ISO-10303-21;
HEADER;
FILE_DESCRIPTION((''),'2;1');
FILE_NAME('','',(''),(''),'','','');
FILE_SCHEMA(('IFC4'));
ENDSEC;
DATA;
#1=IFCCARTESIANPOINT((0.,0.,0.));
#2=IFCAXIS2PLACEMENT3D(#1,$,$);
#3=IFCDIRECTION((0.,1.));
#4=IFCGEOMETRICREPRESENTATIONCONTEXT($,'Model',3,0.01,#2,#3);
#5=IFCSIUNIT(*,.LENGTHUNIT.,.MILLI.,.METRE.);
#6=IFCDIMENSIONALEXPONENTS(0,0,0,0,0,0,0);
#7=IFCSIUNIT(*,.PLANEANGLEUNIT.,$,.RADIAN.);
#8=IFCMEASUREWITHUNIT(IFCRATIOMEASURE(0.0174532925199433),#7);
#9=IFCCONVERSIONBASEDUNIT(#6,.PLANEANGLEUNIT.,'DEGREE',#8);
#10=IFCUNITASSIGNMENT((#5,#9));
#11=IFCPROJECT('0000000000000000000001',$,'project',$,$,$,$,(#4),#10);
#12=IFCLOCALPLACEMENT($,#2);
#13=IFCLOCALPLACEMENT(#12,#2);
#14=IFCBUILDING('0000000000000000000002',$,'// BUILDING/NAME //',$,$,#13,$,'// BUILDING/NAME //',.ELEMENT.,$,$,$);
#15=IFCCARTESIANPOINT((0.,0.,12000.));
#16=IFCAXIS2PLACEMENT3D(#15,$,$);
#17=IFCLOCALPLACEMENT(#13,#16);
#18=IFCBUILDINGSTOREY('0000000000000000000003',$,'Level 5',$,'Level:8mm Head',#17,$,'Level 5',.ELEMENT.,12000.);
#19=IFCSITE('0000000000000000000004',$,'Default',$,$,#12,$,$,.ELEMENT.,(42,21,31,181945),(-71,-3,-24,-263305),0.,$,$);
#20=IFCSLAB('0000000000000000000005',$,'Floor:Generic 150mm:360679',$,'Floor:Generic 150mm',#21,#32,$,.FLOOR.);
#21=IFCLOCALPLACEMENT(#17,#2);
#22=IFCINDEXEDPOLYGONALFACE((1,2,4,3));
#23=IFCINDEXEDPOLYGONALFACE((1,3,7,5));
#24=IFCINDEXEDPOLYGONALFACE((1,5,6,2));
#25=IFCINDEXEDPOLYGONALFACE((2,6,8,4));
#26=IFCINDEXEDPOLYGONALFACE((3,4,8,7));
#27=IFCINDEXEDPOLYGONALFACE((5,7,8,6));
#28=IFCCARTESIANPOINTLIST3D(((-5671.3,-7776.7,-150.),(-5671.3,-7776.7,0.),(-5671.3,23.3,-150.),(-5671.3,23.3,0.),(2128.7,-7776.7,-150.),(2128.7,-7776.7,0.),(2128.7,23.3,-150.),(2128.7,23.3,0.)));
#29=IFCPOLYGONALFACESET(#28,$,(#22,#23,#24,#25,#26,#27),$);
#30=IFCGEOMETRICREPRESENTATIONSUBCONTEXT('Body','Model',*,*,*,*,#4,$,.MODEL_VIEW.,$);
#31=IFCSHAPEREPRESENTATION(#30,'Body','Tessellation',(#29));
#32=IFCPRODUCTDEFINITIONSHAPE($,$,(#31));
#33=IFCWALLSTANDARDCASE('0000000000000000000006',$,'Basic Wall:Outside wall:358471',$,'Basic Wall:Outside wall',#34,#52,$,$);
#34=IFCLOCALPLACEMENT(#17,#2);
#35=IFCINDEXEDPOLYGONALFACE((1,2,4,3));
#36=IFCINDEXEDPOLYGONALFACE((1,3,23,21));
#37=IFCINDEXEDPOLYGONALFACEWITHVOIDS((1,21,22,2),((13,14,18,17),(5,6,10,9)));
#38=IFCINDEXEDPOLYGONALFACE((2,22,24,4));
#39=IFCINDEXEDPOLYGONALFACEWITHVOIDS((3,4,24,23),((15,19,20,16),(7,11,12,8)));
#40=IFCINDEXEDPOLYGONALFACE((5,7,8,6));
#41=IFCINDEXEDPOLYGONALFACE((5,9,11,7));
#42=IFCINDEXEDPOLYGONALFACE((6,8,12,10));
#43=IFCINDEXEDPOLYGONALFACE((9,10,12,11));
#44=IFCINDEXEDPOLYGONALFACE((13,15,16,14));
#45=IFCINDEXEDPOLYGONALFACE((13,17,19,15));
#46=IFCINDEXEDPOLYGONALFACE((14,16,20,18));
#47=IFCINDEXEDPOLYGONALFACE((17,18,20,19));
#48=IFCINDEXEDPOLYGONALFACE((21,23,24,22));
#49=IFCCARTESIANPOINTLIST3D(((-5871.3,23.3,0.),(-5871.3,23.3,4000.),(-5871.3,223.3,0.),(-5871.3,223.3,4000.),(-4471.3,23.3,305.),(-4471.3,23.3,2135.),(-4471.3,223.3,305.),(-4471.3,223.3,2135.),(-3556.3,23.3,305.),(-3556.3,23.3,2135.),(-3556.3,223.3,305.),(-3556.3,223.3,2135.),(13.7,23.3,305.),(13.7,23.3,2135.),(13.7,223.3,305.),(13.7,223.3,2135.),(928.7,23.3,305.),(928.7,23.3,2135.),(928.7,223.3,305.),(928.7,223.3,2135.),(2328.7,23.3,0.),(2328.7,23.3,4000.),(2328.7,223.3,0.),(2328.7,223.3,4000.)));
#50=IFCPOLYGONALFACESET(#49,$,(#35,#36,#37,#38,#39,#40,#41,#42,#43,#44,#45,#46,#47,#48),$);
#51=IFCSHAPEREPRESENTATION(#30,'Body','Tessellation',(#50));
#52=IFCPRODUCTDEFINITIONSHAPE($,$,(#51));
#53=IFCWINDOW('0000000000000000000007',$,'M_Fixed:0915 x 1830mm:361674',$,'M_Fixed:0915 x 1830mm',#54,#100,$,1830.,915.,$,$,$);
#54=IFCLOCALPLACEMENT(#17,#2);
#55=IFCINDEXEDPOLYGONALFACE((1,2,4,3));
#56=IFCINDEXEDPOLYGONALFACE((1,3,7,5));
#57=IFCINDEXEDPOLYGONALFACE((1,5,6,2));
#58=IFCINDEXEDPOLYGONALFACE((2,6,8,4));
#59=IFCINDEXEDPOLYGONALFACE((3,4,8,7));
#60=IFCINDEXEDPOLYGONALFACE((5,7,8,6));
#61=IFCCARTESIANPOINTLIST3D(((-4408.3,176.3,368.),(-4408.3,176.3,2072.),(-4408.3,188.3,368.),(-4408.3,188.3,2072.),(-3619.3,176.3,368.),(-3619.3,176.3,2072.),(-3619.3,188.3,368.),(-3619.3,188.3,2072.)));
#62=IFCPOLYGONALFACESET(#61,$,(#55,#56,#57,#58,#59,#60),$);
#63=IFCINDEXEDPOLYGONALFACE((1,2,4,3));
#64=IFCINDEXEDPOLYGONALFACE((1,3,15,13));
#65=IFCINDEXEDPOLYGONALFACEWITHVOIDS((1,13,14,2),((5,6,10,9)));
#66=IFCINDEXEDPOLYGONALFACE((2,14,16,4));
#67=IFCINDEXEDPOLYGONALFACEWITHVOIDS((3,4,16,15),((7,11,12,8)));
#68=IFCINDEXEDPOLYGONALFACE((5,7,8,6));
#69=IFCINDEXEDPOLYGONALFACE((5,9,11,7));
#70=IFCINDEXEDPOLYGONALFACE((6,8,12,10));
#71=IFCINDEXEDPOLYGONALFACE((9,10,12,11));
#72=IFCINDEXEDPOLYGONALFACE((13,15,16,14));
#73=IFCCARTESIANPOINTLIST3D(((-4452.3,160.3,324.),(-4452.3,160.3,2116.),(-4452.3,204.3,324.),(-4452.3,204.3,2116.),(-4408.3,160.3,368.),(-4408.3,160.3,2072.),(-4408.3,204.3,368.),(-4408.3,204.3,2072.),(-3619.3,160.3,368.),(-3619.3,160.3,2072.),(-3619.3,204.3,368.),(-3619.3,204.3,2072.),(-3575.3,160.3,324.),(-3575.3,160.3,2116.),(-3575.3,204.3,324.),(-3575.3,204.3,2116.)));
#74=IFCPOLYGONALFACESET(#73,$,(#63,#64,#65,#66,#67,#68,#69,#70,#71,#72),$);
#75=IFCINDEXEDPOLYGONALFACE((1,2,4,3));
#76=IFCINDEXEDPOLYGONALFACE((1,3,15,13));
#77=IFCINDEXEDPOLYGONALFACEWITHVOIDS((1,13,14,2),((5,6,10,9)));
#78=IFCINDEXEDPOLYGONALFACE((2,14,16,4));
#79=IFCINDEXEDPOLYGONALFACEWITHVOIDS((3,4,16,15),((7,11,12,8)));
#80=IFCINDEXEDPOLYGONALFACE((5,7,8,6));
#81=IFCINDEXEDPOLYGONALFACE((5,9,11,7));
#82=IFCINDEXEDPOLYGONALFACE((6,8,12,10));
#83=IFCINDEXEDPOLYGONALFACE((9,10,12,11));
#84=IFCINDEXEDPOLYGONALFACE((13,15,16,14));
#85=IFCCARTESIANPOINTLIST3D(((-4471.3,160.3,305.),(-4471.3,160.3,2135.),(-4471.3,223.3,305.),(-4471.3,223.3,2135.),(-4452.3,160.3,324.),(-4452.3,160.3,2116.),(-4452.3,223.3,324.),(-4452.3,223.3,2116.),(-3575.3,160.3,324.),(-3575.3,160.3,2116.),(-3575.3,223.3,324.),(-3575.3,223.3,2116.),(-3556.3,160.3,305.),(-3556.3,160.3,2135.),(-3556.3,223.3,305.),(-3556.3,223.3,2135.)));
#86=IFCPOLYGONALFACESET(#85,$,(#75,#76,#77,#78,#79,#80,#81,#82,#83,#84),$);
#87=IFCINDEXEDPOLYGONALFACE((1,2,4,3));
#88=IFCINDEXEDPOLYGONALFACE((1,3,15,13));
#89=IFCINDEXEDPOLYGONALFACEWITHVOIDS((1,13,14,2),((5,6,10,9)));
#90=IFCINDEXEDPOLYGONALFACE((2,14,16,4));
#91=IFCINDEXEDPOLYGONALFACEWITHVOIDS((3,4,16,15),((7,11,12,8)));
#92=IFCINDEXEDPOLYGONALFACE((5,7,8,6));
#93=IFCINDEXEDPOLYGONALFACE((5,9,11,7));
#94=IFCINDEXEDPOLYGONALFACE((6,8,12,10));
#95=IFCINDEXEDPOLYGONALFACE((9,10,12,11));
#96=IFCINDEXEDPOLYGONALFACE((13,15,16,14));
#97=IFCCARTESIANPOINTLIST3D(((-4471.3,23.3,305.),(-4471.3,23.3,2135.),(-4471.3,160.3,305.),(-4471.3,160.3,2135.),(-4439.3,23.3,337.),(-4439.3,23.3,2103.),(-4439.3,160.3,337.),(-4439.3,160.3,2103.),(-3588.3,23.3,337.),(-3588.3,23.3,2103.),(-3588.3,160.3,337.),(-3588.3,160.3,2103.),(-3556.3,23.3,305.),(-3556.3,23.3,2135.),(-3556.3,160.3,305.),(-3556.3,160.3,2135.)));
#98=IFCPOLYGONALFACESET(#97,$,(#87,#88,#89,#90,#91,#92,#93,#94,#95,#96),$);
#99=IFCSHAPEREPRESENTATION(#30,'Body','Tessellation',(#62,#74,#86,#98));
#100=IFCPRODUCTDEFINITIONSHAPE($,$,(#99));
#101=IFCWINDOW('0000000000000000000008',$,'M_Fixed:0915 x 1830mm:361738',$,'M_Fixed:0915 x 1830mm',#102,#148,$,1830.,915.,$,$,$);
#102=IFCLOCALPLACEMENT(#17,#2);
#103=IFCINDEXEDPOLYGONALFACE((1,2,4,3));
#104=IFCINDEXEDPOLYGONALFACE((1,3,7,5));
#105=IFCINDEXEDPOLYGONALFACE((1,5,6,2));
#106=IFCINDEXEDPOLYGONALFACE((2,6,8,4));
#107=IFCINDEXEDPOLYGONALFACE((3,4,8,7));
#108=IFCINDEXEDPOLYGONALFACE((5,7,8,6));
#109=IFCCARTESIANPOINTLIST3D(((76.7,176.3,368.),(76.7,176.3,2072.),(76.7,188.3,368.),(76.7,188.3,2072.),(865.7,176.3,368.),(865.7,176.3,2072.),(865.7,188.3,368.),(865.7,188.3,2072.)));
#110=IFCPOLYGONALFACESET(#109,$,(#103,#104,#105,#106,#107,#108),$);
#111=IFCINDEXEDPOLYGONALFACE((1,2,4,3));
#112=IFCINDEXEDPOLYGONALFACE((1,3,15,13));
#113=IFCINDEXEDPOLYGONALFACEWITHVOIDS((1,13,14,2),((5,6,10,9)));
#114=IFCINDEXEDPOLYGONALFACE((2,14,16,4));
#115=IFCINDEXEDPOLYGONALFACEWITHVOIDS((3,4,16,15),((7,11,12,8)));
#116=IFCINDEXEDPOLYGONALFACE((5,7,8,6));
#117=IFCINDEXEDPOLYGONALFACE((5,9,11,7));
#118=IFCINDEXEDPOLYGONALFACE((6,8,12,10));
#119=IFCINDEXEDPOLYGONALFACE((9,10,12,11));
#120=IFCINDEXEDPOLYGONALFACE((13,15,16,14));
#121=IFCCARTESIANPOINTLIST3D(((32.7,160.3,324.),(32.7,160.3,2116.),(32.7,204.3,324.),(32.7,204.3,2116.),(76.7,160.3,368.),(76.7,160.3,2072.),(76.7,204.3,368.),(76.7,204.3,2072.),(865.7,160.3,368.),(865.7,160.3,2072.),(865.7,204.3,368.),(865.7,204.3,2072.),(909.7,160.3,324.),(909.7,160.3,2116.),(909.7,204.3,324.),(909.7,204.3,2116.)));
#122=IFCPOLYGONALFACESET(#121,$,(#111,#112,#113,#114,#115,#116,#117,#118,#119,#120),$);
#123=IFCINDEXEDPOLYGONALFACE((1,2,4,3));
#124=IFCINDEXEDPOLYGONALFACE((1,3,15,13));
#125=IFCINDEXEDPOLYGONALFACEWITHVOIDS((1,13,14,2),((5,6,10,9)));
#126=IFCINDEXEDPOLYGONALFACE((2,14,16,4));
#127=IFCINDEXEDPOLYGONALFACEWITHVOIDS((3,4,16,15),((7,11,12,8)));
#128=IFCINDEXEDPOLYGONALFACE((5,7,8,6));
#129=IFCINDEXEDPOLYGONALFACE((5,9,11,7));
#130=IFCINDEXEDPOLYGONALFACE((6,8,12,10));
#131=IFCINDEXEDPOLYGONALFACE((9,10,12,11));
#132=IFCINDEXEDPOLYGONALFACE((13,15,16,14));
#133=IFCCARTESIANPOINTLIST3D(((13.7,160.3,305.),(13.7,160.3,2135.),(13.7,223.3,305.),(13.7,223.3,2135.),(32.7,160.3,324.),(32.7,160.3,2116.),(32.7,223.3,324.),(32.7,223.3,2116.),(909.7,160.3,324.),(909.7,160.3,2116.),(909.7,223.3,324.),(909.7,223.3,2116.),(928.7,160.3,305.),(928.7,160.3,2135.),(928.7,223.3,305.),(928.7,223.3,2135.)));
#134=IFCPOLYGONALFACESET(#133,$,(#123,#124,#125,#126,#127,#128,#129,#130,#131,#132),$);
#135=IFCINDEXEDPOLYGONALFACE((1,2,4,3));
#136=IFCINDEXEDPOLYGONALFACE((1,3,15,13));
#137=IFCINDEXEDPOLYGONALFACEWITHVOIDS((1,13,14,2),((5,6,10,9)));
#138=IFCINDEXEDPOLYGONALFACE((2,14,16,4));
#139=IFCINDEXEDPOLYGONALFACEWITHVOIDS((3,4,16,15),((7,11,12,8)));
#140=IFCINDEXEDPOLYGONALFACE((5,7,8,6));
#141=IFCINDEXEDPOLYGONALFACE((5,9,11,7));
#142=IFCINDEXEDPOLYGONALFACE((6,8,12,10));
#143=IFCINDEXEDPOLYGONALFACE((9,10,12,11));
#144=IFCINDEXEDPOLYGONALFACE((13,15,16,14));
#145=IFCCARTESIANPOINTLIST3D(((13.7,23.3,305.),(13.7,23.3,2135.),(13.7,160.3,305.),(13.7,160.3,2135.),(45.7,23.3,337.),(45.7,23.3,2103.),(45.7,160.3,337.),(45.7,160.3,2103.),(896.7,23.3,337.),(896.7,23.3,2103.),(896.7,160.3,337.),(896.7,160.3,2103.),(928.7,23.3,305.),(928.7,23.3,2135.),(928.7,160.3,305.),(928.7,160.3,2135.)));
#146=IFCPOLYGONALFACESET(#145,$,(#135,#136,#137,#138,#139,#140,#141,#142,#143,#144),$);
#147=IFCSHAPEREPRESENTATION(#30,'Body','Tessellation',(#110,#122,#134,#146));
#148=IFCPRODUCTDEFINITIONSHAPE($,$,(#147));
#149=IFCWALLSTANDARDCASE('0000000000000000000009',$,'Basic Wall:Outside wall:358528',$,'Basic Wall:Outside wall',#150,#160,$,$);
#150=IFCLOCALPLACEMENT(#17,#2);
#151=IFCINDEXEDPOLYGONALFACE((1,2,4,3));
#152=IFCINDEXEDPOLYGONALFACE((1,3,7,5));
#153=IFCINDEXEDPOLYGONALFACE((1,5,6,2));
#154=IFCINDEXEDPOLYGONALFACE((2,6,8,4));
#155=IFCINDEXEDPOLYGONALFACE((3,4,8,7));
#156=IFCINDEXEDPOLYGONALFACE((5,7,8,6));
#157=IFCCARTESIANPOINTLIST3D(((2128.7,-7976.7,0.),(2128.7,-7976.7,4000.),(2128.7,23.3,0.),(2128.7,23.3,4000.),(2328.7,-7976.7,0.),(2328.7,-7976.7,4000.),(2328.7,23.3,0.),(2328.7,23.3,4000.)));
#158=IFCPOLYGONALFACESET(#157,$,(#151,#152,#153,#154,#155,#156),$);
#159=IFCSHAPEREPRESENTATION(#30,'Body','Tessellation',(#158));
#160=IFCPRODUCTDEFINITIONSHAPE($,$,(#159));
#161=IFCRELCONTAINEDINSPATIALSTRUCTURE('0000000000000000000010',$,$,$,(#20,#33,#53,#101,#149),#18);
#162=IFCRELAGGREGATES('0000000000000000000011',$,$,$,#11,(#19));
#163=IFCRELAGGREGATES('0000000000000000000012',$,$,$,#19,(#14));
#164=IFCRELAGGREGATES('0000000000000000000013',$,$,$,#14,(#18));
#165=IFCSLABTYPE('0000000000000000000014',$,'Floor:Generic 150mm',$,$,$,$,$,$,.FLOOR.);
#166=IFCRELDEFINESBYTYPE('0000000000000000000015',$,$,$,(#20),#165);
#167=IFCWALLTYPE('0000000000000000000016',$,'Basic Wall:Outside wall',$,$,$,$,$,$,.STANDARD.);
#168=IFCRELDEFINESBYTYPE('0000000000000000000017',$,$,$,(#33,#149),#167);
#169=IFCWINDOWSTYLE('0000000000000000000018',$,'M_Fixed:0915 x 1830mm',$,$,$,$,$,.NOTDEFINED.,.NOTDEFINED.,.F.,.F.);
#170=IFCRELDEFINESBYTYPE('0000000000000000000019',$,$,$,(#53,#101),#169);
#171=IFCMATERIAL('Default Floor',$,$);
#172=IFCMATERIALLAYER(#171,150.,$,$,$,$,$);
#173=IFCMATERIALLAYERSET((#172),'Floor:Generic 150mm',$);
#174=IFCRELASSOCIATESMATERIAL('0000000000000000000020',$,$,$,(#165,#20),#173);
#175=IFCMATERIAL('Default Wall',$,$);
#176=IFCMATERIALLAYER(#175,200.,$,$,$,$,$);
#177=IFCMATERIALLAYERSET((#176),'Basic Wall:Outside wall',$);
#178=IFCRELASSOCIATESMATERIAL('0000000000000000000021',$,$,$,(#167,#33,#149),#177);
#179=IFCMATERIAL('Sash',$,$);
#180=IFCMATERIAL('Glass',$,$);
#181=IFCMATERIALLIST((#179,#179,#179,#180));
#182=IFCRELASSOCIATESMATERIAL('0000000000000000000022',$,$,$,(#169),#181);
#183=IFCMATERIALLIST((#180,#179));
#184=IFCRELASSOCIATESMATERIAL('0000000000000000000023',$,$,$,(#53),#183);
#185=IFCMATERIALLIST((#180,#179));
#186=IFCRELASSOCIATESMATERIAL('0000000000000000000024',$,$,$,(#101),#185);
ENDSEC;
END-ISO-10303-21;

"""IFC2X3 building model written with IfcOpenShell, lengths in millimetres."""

from ifc_helpers import new_model, entity, si_unit, converted_unit, direction, frame, frame_2d, origin, place, context, subcontext, project, spatial, polyline, rectangle, outline, extrude, clip, halfspace, source, transform, mapped, material, material_list, layer, layer_set, layer_usage, type_object, type_shapes, element, fill, save


model = new_model("IFC2X3")

# Units and contexts
model_context = context("Model", 3, precision=0.01, world=origin(), true_north=direction((0.0, 1.0)))
body_context = subcontext(model_context, "Body", "Model", "MODEL_VIEW")
ifc_project = project(units=[si_unit("LENGTHUNIT", "METRE", prefix="MILLI"), converted_unit("PLANEANGLEUNIT", "DEGREE", entity("IfcRatioMeasure", 0.0174532925199433), si_unit("PLANEANGLEUNIT", "RADIAN"), dimensions=[0, 0, 0, 0, 0, 0, 0])], contexts=[model_context])

# Site, building, storey
site_placement = place(None, origin())
site = spatial("IfcSite", under=ifc_project, at=site_placement, Name="Default", CompositionType="ELEMENT", RefLatitude=(42, 21, 31, 181945), RefLongitude=(-71, -3, -24, -263305), RefElevation=0.0)
building_placement = place(site_placement, origin())
building = spatial("IfcBuilding", under=site, at=building_placement, Name="// BUILDING/NAME //", LongName="// BUILDING/NAME //", CompositionType="ELEMENT")
storey_placement = place(building_placement, frame((0.0, 0.0, 12000.0)))
storey = spatial("IfcBuildingStorey", under=building, at=storey_placement, Name="Level 5", ObjectType="Level:8mm Head", LongName="Level 5", CompositionType="ELEMENT", Elevation=12000.0)

# Slab
ifc_material_1 = material(Name="Default Floor")
ifc_layer_1 = layer(ifc_material_1, 150.0)
ifc_layer_set_1 = layer_set([ifc_layer_1], Name="Floor:Generic 150mm")
ifc_layer_usage_1 = layer_usage(ifc_layer_set_1, "AXIS3", "POSITIVE", 0.0)
slab_type = type_object("IfcSlabType", Name="Floor:Generic 150mm", PredefinedType="FLOOR", material=ifc_layer_set_1)
slab_placement = place(storey_placement, origin())
element("IfcSlab", 1, at=slab_placement, inside=storey, type_object=slab_type, material=ifc_layer_usage_1, Name="Floor:Generic 150mm:360679", ObjectType="Floor:Generic 150mm", PredefinedType="FLOOR", context=body_context, shape_type="SweptSolid", body=[
    extrude(rectangle(XDim=7800.0, YDim=7800.0, at=frame_2d((0.0, 0.0), x_axis=(1.0, 0.0))), frame((-1771.3, -3876.7, 0.0), z_axis=(0.0, 0.0, -1.0), x_axis=(0.0, 1.0, 0.0)), (0.0, 0.0, 1.0), 150.0),
])

# Wall, openings, windows
ifc_material_2 = material(Name="Default Wall")
ifc_layer_2 = layer(ifc_material_2, 200.0)
ifc_layer_set_2 = layer_set([ifc_layer_2], Name="Basic Wall:Outside wall")
ifc_layer_usage_2 = layer_usage(ifc_layer_set_2, "AXIS2", "NEGATIVE", 100.0)
wall_type_1 = type_object("IfcWallType", Name="Basic Wall:Outside wall", PredefinedType="STANDARD", material=ifc_layer_set_2)
wall_1_placement = place(storey_placement, frame((-5871.3, 123.3, 0.0)))
wall_1 = element("IfcWallStandardCase", 2, at=wall_1_placement, inside=storey, type_object=wall_type_1, material=ifc_layer_usage_2, Name="Basic Wall:Outside wall:358471", ObjectType="Basic Wall:Outside wall", context=body_context, shape_type="Clipping", body=[
    clip(extrude(rectangle(XDim=8200.0, YDim=200.0, at=frame_2d((4100.0, 0.0), x_axis=(-1.0, 0.0))), origin(), (0.0, 0.0, 1.0), 4000.0), halfspace(frame((0.0, 0.0, -12000.0)), True)),
])
opening_1_placement = place(wall_1_placement, frame((1400.0, -100.0, 305.0)))
opening_1 = element("IfcOpeningElement", 3, at=opening_1_placement, cuts=wall_1, ObjectType="Opening", context=body_context, shape_type="SweptSolid", body=[
    extrude(rectangle(XDim=1830.0, YDim=915.0, at=frame_2d((915.0, 457.5), x_axis=(1.0, 0.0))), frame((0.0, 0.0, 0.0), z_axis=(0.0, 1.0, 0.0), x_axis=(0.0, 0.0, 1.0)), (0.0, 0.0, 1.0), 200.0),
])
opening_2_placement = place(wall_1_placement, frame((5885.0, -100.0, 305.0)))
opening_2 = element("IfcOpeningElement", 4, at=opening_2_placement, cuts=wall_1, ObjectType="Opening", context=body_context, shape_type="SweptSolid", body=[
    extrude(rectangle(XDim=1830.0, YDim=915.0, at=frame_2d((915.0, 457.5), x_axis=(1.0, 0.0))), frame((0.0, 0.0, 0.0), z_axis=(0.0, 1.0, 0.0), x_axis=(0.0, 0.0, 1.0)), (0.0, 0.0, 1.0), 200.0),
])
ifc_material_3 = material(Name="Glass")
ifc_material_4 = material(Name="Sash")
ifc_material_list_1 = material_list([ifc_material_3, ifc_material_4])
ifc_material_list_2 = material_list([ifc_material_4, ifc_material_4, ifc_material_4, ifc_material_3])
window_style = type_object("IfcWindowStyle", Name="M_Fixed:0915 x 1830mm", ConstructionType="NOTDEFINED", OperationType="NOTDEFINED", ParameterTakesPrecedence=False, Sizeable=False, material=ifc_material_list_2)
shared_shape = source(origin(), body_context, "Body", "SweptSolid", [
    extrude(rectangle(XDim=12.0, YDim=789.0, at=frame_2d((0.0, 0.0), x_axis=(1.0, 0.0))), frame((457.5, 159.0, 63.0), z_axis=(0.0, 0.0, 1.0), x_axis=(0.0, -1.0, 0.0)), (0.0, 0.0, 1.0), 1704.0),
    extrude(outline(polyline([(-438.5, -896.0), (438.5, -896.0), (438.5, 896.0), (-438.5, 896.0), (-438.5, -896.0)]), holes=[polyline([(-394.5, -852.0), (-394.5, 852.0), (394.5, 852.0), (394.5, -852.0), (-394.5, -852.0)])]), frame((457.5, 137.0, 915.0), z_axis=(0.0, 1.0, 0.0), x_axis=(1.0, 0.0, 0.0)), (0.0, 0.0, 1.0), 44.0),
    extrude(outline(polyline([(-457.5, -915.0), (457.5, -915.0), (457.5, 915.0), (-457.5, 915.0), (-457.5, -915.0)]), holes=[polyline([(-438.5, -896.0), (-438.5, 896.0), (438.5, 896.0), (438.5, -896.0), (-438.5, -896.0)])]), frame((457.5, 137.0, 915.0), z_axis=(0.0, 1.0, 0.0), x_axis=(1.0, 0.0, 0.0)), (0.0, 0.0, 1.0), 63.0),
    extrude(outline(polyline([(-457.5, -915.0), (457.5, -915.0), (457.5, 915.0), (-457.5, 915.0), (-457.5, -915.0)]), holes=[polyline([(-425.5, -883.0), (-425.5, 883.0), (425.5, 883.0), (425.5, -883.0), (-425.5, -883.0)])]), frame((457.5, 0.0, 915.0), z_axis=(0.0, 1.0, 0.0), x_axis=(1.0, 0.0, 0.0)), (0.0, 0.0, 1.0), 137.0),
])
type_shapes(window_style, [shared_shape])
window_1_placement = place(opening_1_placement, origin())
window_1 = element("IfcWindow", 5, at=window_1_placement, inside=storey, type_object=window_style, material=ifc_material_list_1, Name="M_Fixed:0915 x 1830mm:361674", ObjectType="M_Fixed:0915 x 1830mm", OverallHeight=1830.0, OverallWidth=915.0, context=body_context, shape_type="MappedRepresentation", body=[
    mapped(shared_shape, transform((0.0, 0.0, 0.0), scale=1.0)),
])
fill(opening_1, window_1)
ifc_material_list_3 = material_list([ifc_material_3, ifc_material_4])
window_2_placement = place(opening_2_placement, origin())
window_2 = element("IfcWindow", 6, at=window_2_placement, inside=storey, type_object=window_style, material=ifc_material_list_3, Name="M_Fixed:0915 x 1830mm:361738", ObjectType="M_Fixed:0915 x 1830mm", OverallHeight=1830.0, OverallWidth=915.0, context=body_context, shape_type="MappedRepresentation", body=[
    mapped(shared_shape, transform((0.0, 0.0, 0.0), scale=1.0)),
])
fill(opening_2, window_2)

# Wall
ifc_layer_usage_3 = layer_usage(ifc_layer_set_2, "AXIS2", "NEGATIVE", 100.0)
wall_2_placement = place(storey_placement, frame((2228.7, 23.3, 0.0), z_axis=(0.0, 0.0, 1.0), x_axis=(0.0, -1.0, 0.0)))
element("IfcWallStandardCase", 7, at=wall_2_placement, inside=storey, type_object=wall_type_1, material=ifc_layer_usage_3, Name="Basic Wall:Outside wall:358528", ObjectType="Basic Wall:Outside wall", context=body_context, shape_type="Clipping", body=[
    clip(extrude(rectangle(XDim=8000.0, YDim=200.0, at=frame_2d((4000.0, 0.0), x_axis=(-1.0, 0.0))), origin(), (0.0, 0.0, 1.0), 4000.0), halfspace(frame((0.0, 0.0, -12000.0)), True)),
])

save(model, "model.ifc")
